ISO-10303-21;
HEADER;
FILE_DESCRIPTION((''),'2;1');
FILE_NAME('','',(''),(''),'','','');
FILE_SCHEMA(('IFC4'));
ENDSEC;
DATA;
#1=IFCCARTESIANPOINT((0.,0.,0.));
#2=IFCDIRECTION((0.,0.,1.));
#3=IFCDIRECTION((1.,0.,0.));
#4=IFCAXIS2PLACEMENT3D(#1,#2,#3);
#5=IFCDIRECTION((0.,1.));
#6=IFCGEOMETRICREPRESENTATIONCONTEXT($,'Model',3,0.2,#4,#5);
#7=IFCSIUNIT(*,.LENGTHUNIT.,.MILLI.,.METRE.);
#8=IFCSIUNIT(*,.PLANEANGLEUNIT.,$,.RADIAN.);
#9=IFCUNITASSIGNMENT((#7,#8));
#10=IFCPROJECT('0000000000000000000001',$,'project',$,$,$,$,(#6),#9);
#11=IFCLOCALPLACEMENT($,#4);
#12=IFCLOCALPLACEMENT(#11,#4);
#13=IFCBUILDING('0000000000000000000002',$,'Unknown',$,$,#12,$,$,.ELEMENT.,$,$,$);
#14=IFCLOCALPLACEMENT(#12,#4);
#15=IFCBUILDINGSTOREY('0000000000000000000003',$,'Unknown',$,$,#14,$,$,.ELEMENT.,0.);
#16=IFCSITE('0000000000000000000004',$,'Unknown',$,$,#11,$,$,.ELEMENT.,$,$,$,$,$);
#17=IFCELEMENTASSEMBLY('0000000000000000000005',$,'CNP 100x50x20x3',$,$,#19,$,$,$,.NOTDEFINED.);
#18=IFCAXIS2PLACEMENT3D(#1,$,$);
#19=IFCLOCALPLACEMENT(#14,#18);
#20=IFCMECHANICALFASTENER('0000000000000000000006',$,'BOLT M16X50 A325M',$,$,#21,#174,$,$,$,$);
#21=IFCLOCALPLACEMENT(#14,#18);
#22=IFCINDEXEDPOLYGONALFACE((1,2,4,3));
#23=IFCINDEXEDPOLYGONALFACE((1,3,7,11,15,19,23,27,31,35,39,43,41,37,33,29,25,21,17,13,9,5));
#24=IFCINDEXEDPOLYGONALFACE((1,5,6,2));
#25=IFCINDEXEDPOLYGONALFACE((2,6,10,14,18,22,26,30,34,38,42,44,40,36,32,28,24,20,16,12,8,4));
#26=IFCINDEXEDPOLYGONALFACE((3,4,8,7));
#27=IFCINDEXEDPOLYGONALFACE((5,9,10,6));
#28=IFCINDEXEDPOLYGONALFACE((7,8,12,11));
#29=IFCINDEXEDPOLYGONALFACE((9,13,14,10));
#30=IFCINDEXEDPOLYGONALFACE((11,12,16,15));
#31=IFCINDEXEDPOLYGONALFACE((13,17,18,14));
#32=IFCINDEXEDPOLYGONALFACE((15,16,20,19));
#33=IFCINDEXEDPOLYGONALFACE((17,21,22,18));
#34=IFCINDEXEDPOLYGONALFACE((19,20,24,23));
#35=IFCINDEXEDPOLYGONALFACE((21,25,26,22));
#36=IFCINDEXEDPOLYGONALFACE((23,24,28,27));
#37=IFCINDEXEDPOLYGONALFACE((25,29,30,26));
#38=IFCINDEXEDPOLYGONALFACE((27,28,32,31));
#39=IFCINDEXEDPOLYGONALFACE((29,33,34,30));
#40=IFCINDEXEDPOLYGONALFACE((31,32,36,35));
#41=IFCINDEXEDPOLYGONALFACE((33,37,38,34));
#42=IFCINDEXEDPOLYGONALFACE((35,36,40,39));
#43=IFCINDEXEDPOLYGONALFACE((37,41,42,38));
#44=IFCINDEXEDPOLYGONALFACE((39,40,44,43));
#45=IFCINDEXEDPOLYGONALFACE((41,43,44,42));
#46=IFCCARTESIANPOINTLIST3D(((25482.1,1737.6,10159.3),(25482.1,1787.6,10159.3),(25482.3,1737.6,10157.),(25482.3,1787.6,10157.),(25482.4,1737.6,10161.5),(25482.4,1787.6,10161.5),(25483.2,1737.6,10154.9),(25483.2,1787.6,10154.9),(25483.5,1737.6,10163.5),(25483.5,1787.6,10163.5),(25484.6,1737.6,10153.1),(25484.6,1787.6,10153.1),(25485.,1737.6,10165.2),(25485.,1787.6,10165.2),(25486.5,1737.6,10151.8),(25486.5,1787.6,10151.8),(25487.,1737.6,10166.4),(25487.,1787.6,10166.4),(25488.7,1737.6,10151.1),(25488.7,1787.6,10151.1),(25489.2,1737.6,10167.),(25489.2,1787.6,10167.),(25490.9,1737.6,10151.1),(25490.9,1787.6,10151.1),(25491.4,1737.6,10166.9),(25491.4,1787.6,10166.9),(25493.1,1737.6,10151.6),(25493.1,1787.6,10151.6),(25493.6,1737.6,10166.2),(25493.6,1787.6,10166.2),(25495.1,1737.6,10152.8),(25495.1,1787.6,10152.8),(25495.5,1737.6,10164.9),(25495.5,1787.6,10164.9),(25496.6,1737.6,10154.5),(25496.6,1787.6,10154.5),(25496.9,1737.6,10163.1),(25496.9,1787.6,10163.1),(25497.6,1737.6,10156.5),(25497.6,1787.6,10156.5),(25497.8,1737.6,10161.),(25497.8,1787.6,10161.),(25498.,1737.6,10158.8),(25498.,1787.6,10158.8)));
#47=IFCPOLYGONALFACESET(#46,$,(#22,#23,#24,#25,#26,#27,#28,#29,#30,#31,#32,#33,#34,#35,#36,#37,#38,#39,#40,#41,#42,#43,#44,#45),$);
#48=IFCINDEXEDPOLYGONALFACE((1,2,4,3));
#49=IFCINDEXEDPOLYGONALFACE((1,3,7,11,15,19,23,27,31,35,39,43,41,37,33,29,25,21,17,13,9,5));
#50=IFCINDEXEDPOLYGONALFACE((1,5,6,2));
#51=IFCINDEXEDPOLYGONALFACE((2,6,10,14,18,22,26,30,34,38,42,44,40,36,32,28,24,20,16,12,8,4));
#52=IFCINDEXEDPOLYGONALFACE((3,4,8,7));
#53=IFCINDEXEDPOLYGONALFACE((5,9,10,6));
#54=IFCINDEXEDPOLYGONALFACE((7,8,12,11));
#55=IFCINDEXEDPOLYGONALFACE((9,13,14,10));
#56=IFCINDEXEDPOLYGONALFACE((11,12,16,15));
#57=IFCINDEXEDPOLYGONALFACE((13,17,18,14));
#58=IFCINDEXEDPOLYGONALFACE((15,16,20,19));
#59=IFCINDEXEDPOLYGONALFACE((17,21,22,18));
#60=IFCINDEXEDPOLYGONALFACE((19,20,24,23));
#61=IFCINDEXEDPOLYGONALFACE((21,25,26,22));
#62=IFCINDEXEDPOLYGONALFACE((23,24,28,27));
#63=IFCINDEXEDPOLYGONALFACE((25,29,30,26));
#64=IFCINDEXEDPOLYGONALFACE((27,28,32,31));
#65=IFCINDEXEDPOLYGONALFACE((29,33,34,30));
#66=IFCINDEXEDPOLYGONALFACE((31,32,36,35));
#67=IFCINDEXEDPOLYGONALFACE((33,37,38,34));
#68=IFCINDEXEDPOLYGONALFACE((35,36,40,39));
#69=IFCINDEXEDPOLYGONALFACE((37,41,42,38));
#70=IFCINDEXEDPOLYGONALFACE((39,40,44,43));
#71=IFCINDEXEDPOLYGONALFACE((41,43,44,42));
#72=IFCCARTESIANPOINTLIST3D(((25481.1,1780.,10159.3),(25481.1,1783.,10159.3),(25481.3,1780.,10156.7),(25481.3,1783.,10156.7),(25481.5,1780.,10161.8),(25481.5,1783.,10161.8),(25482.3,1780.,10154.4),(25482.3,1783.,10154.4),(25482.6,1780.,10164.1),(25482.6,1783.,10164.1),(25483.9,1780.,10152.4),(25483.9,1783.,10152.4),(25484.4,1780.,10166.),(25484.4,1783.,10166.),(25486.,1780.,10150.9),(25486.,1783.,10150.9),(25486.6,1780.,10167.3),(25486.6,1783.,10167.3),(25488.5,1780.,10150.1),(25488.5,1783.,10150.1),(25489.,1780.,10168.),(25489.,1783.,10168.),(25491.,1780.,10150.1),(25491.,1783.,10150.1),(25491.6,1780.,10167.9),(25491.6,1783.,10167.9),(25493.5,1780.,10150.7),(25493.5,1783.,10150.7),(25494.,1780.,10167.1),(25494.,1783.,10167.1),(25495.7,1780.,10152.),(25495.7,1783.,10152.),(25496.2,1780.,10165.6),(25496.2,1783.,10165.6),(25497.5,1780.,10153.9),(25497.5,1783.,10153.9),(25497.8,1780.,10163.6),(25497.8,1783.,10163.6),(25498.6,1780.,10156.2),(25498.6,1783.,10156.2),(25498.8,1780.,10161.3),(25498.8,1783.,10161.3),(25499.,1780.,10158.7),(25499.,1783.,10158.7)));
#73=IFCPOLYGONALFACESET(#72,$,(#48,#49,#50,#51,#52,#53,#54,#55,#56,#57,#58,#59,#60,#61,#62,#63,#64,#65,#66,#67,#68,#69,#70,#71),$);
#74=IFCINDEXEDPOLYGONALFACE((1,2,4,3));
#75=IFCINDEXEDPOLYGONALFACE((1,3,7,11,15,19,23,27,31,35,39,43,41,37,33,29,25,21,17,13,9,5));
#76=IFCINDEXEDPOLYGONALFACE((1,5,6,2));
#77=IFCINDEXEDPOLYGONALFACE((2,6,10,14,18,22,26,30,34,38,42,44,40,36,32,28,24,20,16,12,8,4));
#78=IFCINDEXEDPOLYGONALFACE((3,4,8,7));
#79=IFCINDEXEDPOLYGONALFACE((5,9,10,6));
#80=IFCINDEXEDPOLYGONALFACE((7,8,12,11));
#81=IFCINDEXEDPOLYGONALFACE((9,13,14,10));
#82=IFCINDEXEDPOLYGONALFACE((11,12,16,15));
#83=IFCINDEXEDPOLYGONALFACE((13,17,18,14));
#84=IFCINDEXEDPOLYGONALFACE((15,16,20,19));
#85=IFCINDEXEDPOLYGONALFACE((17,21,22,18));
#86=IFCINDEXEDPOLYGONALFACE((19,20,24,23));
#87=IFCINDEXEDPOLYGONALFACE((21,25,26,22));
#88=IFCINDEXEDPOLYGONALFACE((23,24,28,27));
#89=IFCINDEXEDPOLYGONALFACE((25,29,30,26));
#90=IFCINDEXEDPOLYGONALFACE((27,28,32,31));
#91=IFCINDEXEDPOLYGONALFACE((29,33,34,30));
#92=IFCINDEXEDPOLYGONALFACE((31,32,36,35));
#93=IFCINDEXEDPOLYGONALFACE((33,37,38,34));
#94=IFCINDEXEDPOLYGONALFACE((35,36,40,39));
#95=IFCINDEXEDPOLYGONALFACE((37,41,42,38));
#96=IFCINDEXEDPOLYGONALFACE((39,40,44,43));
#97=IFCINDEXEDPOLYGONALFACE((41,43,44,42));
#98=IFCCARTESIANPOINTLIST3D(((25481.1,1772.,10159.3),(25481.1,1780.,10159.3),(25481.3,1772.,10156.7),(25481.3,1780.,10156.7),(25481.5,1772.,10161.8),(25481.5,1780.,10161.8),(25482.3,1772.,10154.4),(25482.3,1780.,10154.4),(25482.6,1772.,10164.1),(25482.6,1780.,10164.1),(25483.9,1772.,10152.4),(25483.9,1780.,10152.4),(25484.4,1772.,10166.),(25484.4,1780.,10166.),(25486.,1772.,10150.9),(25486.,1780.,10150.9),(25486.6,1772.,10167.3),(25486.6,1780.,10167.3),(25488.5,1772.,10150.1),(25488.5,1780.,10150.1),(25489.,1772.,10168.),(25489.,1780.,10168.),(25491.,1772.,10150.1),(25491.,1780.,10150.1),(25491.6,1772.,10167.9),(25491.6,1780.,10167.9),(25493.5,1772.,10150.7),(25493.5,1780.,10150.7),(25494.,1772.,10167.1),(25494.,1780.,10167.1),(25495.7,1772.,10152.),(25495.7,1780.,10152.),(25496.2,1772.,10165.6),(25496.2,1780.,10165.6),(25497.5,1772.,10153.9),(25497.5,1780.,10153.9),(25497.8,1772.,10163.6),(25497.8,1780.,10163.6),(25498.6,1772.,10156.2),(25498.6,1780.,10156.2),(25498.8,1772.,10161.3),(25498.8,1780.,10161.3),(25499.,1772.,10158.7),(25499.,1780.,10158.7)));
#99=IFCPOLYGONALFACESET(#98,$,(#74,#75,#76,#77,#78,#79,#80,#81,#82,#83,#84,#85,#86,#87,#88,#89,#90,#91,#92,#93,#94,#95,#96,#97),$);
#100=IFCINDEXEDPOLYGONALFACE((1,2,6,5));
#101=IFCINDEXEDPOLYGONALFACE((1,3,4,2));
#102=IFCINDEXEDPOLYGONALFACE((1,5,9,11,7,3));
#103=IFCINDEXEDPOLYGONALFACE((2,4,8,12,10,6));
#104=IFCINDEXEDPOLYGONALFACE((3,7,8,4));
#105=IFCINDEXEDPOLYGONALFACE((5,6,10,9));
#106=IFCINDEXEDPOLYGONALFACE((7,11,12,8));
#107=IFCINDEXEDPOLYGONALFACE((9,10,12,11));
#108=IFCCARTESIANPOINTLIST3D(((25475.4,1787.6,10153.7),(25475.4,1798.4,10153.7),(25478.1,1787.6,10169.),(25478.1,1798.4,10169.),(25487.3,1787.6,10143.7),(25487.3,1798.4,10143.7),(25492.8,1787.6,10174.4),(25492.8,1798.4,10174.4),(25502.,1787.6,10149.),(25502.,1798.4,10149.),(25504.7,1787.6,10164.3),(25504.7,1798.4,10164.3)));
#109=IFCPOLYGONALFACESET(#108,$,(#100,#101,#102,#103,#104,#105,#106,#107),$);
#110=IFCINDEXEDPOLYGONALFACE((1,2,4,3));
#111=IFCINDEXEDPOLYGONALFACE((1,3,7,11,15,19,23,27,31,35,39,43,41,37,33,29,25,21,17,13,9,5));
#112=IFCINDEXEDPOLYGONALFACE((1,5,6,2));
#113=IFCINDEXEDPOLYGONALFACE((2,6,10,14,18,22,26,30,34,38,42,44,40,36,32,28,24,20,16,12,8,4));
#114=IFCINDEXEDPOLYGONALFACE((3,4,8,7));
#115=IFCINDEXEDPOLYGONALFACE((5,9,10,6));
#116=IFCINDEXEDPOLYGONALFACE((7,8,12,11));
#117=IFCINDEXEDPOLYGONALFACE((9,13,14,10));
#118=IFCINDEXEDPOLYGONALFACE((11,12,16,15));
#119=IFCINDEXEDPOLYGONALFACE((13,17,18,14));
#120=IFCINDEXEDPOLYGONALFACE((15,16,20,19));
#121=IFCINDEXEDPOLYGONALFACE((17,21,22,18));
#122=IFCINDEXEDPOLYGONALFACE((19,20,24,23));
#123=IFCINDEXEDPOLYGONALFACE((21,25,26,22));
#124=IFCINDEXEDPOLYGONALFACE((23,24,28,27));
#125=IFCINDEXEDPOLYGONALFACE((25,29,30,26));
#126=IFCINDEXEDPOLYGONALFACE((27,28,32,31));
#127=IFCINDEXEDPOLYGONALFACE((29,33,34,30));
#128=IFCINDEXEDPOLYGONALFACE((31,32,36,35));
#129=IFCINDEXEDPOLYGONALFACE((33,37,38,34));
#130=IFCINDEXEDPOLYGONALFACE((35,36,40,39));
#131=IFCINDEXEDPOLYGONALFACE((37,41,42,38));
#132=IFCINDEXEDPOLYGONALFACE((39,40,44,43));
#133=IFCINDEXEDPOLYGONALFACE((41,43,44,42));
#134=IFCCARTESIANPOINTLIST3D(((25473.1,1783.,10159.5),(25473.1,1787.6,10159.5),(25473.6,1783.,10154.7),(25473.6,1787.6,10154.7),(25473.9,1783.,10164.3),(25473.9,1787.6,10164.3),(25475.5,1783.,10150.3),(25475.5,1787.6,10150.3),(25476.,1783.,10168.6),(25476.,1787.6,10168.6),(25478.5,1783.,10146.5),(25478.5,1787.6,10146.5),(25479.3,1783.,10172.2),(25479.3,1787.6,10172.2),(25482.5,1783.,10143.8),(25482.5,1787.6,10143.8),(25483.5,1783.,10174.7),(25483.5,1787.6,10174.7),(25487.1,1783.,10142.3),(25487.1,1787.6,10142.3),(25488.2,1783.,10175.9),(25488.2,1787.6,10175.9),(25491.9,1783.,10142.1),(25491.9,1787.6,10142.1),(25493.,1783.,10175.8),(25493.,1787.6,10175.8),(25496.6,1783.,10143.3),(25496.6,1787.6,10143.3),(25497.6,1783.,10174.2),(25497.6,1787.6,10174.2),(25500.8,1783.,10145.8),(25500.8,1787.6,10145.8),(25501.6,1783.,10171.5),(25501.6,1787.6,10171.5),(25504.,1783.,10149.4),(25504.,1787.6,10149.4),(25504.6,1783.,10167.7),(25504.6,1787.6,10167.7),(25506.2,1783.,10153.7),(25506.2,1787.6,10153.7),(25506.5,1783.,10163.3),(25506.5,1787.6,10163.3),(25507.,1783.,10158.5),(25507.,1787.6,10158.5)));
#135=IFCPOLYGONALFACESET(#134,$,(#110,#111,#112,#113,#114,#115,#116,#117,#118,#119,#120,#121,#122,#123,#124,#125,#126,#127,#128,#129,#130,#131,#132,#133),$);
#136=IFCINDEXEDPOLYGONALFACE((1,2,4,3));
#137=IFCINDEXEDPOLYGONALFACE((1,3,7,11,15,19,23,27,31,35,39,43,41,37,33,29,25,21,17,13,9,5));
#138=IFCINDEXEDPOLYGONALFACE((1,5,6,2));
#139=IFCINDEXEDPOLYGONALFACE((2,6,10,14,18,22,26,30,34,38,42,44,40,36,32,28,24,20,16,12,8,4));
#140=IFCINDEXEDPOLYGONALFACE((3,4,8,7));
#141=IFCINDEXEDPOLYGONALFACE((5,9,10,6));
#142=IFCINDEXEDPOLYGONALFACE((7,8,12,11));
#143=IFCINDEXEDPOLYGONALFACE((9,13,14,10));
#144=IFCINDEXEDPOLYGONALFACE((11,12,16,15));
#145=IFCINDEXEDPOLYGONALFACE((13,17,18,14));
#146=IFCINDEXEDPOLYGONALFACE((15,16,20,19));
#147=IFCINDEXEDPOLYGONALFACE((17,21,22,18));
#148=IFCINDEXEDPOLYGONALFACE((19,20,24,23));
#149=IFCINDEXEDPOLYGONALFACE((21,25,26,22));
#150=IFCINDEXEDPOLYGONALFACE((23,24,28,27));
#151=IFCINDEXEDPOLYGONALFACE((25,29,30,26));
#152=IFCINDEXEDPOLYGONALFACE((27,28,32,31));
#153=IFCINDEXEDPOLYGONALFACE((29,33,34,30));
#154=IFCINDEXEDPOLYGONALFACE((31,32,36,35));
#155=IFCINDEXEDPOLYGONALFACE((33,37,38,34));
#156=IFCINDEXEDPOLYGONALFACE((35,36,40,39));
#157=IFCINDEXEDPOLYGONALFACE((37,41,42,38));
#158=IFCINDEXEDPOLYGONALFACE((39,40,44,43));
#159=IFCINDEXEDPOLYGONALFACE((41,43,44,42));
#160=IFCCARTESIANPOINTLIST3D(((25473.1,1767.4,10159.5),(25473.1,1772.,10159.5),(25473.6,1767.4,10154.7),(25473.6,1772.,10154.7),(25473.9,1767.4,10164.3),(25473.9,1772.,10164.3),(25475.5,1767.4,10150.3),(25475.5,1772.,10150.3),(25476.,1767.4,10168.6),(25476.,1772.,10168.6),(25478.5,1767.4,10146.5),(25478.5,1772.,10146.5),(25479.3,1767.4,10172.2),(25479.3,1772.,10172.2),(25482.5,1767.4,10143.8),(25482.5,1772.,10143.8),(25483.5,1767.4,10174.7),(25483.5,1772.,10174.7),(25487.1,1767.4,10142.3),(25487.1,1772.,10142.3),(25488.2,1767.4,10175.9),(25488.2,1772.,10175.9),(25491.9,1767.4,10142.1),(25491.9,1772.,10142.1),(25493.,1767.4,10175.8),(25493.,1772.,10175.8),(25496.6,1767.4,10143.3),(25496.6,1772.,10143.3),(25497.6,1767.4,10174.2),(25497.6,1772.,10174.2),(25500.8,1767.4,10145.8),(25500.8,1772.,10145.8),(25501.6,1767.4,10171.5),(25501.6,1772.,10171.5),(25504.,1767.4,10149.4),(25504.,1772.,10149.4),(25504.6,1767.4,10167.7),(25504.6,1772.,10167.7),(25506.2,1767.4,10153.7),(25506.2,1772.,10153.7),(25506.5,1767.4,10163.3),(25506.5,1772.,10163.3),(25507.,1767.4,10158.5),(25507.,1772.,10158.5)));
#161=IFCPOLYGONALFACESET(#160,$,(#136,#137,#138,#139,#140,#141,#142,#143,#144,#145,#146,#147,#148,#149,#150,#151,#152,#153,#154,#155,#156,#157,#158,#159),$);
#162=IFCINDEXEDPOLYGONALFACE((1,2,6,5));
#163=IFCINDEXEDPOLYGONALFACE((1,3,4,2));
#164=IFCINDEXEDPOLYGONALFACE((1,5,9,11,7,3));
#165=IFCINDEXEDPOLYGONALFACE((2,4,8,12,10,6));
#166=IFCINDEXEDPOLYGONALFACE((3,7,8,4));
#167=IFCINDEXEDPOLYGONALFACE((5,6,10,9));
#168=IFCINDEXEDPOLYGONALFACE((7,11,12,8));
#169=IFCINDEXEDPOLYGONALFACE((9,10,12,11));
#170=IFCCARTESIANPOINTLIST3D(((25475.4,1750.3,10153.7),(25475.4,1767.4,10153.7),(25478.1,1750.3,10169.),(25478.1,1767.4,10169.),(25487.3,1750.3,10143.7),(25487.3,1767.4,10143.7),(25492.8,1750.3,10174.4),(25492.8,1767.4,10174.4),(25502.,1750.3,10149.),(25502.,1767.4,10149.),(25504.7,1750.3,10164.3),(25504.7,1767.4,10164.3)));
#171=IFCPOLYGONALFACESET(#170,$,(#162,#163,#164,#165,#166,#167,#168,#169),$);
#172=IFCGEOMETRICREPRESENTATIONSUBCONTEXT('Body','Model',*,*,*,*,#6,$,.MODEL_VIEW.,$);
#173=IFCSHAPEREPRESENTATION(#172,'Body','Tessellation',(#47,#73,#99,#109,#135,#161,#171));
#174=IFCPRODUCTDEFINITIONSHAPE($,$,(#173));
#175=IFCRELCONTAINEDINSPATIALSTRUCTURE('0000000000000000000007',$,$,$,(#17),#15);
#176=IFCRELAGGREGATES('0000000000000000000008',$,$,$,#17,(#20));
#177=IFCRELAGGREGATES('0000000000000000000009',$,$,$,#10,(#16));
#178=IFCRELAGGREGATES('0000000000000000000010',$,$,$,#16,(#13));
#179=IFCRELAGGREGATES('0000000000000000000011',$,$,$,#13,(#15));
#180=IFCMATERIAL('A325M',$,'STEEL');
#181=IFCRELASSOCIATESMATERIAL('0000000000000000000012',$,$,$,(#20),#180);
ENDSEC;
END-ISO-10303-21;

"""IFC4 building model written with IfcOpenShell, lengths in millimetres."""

from ifc_helpers import new_model, si_unit, direction, frame, origin_with_axes, place, context, subcontext, project, spatial, line, arc, indexed_curve, outline, extrude, source, transform, mapped, material, element, aggregate, save


model = new_model("IFC4")

# Units and contexts
model_context = context("Model", 3, precision=0.2, world=origin_with_axes(), true_north=direction((0.0, 1.0)))
body_context = subcontext(model_context, "Body", "Model", "MODEL_VIEW")
ifc_project = project(units=[si_unit("LENGTHUNIT", "METRE", prefix="MILLI"), si_unit("PLANEANGLEUNIT", "RADIAN")], contexts=[model_context])

# Site, building, storey
site_placement = place(None, origin_with_axes())
site = spatial("IfcSite", under=ifc_project, at=site_placement, Name="Unknown", CompositionType="ELEMENT")
building_placement = place(site_placement, origin_with_axes())
building = spatial("IfcBuilding", under=site, at=building_placement, Name="Unknown", CompositionType="ELEMENT")
storey_placement = place(building_placement, origin_with_axes())
storey = spatial("IfcBuildingStorey", under=building, at=storey_placement, Name="Unknown", CompositionType="ELEMENT", Elevation=0.0)

# Shared definitions
ifc_material_1 = material(Name="A325M", Category="STEEL")
shared_shape_1 = source(origin_with_axes(), body_context, "Body", "SweptSolid", [
    extrude(outline(indexed_curve([(8.0, 0.0), (0.0, 8.0), (-8.0, 0.0), (0.0, -8.0)], segments=[arc(1, 2, 3), arc(3, 4, 1)])), frame((0.0, 0.0, 15.6), z_axis=(0.0, 0.0, -1.0), x_axis=(0.0, 1.0, 0.0)), (0.0, 0.0, 1.0), 50.0),
    extrude(outline(indexed_curve([(9.0, 0.0), (0.0, 9.0), (-9.0, 0.0), (0.0, -9.0)], segments=[arc(1, 2, 3), arc(3, 4, 1)])), frame((0.0, 0.0, 11.0), z_axis=(0.0, 0.0, -1.0), x_axis=(0.0, 1.0, 0.0)), (0.0, 0.0, 1.0), 3.0),
    extrude(outline(indexed_curve([(9.0, 0.0), (0.0, 9.0), (-9.0, 0.0), (0.0, -9.0)], segments=[arc(1, 2, 3), arc(3, 4, 1)])), frame((0.0, 0.0, 8.0), z_axis=(0.0, 0.0, -1.0), x_axis=(0.0, 1.0, 0.0)), (0.0, 0.0, 1.0), 8.0),
    extrude(outline(indexed_curve([(15.6, 0.0), (7.8, 13.5), (-7.8, 13.5), (-15.6, 0.0), (-7.8, -13.5), (7.8, -13.5)], segments=[line(1, 2, 3, 4, 5, 6, 1)])), frame((0.0, 0.0, 26.4), z_axis=(0.0, 0.0, -1.0), x_axis=(0.0, 1.0, 0.0)), (0.0, 0.0, 1.0), 10.8),
    extrude(outline(indexed_curve([(17.0, 0.0), (0.0, 17.0), (-17.0, 0.0), (0.0, -17.0)], segments=[arc(1, 2, 3), arc(3, 4, 1)])), frame((0.0, 0.0, 15.6), z_axis=(0.0, 0.0, -1.0), x_axis=(0.0, 1.0, 0.0)), (0.0, 0.0, 1.0), 4.6),
    extrude(outline(indexed_curve([(17.0, 0.0), (0.0, 17.0), (-17.0, 0.0), (0.0, -17.0)], segments=[arc(1, 2, 3), arc(3, 4, 1)])), frame((0.0, 0.0, 0.0), z_axis=(0.0, 0.0, -1.0), x_axis=(0.0, 1.0, 0.0)), (0.0, 0.0, 1.0), 4.6),
    extrude(outline(indexed_curve([(15.6, 0.0), (7.8, 13.5), (-7.8, 13.5), (-15.6, 0.0), (-7.8, -13.5), (7.8, -13.5)], segments=[line(1, 2, 3, 4, 5, 6, 1)])), frame((0.0, 0.0, -4.6), z_axis=(0.0, 0.0, -1.0), x_axis=(0.0, 1.0, 0.0)), (0.0, 0.0, 1.0), 17.1),
])

# Element assembly, mechanical fastener
assembly_1_placement = place(storey_placement, frame((25552.5, 1805.0, 10153.1), z_axis=(0.173648, 0.0, 0.984808), x_axis=(-0.984808, 0.0, 0.173648)))
assembly_1 = element("IfcElementAssembly", 1, at=assembly_1_placement, inside=storey, Name="CNP 100x50x20x3", PredefinedType="NOTDEFINED")
mechanical_fastener_1_placement = place(assembly_1_placement, frame((62.5, 33.0, -5.0), z_axis=(0.0, -1.0, 0.0), x_axis=(-1.0, 0.0, 0.0)))
mechanical_fastener_1 = element("IfcMechanicalFastener", 2, at=mechanical_fastener_1_placement, material=ifc_material_1, Name="BOLT M16X50 A325M", context=body_context, shape_type="MappedRepresentation", body=[
    mapped(shared_shape_1, transform((0.0, 0.0, 0.0))),
])
aggregate(assembly_1, [mechanical_fastener_1])

save(model, "model.ifc")
